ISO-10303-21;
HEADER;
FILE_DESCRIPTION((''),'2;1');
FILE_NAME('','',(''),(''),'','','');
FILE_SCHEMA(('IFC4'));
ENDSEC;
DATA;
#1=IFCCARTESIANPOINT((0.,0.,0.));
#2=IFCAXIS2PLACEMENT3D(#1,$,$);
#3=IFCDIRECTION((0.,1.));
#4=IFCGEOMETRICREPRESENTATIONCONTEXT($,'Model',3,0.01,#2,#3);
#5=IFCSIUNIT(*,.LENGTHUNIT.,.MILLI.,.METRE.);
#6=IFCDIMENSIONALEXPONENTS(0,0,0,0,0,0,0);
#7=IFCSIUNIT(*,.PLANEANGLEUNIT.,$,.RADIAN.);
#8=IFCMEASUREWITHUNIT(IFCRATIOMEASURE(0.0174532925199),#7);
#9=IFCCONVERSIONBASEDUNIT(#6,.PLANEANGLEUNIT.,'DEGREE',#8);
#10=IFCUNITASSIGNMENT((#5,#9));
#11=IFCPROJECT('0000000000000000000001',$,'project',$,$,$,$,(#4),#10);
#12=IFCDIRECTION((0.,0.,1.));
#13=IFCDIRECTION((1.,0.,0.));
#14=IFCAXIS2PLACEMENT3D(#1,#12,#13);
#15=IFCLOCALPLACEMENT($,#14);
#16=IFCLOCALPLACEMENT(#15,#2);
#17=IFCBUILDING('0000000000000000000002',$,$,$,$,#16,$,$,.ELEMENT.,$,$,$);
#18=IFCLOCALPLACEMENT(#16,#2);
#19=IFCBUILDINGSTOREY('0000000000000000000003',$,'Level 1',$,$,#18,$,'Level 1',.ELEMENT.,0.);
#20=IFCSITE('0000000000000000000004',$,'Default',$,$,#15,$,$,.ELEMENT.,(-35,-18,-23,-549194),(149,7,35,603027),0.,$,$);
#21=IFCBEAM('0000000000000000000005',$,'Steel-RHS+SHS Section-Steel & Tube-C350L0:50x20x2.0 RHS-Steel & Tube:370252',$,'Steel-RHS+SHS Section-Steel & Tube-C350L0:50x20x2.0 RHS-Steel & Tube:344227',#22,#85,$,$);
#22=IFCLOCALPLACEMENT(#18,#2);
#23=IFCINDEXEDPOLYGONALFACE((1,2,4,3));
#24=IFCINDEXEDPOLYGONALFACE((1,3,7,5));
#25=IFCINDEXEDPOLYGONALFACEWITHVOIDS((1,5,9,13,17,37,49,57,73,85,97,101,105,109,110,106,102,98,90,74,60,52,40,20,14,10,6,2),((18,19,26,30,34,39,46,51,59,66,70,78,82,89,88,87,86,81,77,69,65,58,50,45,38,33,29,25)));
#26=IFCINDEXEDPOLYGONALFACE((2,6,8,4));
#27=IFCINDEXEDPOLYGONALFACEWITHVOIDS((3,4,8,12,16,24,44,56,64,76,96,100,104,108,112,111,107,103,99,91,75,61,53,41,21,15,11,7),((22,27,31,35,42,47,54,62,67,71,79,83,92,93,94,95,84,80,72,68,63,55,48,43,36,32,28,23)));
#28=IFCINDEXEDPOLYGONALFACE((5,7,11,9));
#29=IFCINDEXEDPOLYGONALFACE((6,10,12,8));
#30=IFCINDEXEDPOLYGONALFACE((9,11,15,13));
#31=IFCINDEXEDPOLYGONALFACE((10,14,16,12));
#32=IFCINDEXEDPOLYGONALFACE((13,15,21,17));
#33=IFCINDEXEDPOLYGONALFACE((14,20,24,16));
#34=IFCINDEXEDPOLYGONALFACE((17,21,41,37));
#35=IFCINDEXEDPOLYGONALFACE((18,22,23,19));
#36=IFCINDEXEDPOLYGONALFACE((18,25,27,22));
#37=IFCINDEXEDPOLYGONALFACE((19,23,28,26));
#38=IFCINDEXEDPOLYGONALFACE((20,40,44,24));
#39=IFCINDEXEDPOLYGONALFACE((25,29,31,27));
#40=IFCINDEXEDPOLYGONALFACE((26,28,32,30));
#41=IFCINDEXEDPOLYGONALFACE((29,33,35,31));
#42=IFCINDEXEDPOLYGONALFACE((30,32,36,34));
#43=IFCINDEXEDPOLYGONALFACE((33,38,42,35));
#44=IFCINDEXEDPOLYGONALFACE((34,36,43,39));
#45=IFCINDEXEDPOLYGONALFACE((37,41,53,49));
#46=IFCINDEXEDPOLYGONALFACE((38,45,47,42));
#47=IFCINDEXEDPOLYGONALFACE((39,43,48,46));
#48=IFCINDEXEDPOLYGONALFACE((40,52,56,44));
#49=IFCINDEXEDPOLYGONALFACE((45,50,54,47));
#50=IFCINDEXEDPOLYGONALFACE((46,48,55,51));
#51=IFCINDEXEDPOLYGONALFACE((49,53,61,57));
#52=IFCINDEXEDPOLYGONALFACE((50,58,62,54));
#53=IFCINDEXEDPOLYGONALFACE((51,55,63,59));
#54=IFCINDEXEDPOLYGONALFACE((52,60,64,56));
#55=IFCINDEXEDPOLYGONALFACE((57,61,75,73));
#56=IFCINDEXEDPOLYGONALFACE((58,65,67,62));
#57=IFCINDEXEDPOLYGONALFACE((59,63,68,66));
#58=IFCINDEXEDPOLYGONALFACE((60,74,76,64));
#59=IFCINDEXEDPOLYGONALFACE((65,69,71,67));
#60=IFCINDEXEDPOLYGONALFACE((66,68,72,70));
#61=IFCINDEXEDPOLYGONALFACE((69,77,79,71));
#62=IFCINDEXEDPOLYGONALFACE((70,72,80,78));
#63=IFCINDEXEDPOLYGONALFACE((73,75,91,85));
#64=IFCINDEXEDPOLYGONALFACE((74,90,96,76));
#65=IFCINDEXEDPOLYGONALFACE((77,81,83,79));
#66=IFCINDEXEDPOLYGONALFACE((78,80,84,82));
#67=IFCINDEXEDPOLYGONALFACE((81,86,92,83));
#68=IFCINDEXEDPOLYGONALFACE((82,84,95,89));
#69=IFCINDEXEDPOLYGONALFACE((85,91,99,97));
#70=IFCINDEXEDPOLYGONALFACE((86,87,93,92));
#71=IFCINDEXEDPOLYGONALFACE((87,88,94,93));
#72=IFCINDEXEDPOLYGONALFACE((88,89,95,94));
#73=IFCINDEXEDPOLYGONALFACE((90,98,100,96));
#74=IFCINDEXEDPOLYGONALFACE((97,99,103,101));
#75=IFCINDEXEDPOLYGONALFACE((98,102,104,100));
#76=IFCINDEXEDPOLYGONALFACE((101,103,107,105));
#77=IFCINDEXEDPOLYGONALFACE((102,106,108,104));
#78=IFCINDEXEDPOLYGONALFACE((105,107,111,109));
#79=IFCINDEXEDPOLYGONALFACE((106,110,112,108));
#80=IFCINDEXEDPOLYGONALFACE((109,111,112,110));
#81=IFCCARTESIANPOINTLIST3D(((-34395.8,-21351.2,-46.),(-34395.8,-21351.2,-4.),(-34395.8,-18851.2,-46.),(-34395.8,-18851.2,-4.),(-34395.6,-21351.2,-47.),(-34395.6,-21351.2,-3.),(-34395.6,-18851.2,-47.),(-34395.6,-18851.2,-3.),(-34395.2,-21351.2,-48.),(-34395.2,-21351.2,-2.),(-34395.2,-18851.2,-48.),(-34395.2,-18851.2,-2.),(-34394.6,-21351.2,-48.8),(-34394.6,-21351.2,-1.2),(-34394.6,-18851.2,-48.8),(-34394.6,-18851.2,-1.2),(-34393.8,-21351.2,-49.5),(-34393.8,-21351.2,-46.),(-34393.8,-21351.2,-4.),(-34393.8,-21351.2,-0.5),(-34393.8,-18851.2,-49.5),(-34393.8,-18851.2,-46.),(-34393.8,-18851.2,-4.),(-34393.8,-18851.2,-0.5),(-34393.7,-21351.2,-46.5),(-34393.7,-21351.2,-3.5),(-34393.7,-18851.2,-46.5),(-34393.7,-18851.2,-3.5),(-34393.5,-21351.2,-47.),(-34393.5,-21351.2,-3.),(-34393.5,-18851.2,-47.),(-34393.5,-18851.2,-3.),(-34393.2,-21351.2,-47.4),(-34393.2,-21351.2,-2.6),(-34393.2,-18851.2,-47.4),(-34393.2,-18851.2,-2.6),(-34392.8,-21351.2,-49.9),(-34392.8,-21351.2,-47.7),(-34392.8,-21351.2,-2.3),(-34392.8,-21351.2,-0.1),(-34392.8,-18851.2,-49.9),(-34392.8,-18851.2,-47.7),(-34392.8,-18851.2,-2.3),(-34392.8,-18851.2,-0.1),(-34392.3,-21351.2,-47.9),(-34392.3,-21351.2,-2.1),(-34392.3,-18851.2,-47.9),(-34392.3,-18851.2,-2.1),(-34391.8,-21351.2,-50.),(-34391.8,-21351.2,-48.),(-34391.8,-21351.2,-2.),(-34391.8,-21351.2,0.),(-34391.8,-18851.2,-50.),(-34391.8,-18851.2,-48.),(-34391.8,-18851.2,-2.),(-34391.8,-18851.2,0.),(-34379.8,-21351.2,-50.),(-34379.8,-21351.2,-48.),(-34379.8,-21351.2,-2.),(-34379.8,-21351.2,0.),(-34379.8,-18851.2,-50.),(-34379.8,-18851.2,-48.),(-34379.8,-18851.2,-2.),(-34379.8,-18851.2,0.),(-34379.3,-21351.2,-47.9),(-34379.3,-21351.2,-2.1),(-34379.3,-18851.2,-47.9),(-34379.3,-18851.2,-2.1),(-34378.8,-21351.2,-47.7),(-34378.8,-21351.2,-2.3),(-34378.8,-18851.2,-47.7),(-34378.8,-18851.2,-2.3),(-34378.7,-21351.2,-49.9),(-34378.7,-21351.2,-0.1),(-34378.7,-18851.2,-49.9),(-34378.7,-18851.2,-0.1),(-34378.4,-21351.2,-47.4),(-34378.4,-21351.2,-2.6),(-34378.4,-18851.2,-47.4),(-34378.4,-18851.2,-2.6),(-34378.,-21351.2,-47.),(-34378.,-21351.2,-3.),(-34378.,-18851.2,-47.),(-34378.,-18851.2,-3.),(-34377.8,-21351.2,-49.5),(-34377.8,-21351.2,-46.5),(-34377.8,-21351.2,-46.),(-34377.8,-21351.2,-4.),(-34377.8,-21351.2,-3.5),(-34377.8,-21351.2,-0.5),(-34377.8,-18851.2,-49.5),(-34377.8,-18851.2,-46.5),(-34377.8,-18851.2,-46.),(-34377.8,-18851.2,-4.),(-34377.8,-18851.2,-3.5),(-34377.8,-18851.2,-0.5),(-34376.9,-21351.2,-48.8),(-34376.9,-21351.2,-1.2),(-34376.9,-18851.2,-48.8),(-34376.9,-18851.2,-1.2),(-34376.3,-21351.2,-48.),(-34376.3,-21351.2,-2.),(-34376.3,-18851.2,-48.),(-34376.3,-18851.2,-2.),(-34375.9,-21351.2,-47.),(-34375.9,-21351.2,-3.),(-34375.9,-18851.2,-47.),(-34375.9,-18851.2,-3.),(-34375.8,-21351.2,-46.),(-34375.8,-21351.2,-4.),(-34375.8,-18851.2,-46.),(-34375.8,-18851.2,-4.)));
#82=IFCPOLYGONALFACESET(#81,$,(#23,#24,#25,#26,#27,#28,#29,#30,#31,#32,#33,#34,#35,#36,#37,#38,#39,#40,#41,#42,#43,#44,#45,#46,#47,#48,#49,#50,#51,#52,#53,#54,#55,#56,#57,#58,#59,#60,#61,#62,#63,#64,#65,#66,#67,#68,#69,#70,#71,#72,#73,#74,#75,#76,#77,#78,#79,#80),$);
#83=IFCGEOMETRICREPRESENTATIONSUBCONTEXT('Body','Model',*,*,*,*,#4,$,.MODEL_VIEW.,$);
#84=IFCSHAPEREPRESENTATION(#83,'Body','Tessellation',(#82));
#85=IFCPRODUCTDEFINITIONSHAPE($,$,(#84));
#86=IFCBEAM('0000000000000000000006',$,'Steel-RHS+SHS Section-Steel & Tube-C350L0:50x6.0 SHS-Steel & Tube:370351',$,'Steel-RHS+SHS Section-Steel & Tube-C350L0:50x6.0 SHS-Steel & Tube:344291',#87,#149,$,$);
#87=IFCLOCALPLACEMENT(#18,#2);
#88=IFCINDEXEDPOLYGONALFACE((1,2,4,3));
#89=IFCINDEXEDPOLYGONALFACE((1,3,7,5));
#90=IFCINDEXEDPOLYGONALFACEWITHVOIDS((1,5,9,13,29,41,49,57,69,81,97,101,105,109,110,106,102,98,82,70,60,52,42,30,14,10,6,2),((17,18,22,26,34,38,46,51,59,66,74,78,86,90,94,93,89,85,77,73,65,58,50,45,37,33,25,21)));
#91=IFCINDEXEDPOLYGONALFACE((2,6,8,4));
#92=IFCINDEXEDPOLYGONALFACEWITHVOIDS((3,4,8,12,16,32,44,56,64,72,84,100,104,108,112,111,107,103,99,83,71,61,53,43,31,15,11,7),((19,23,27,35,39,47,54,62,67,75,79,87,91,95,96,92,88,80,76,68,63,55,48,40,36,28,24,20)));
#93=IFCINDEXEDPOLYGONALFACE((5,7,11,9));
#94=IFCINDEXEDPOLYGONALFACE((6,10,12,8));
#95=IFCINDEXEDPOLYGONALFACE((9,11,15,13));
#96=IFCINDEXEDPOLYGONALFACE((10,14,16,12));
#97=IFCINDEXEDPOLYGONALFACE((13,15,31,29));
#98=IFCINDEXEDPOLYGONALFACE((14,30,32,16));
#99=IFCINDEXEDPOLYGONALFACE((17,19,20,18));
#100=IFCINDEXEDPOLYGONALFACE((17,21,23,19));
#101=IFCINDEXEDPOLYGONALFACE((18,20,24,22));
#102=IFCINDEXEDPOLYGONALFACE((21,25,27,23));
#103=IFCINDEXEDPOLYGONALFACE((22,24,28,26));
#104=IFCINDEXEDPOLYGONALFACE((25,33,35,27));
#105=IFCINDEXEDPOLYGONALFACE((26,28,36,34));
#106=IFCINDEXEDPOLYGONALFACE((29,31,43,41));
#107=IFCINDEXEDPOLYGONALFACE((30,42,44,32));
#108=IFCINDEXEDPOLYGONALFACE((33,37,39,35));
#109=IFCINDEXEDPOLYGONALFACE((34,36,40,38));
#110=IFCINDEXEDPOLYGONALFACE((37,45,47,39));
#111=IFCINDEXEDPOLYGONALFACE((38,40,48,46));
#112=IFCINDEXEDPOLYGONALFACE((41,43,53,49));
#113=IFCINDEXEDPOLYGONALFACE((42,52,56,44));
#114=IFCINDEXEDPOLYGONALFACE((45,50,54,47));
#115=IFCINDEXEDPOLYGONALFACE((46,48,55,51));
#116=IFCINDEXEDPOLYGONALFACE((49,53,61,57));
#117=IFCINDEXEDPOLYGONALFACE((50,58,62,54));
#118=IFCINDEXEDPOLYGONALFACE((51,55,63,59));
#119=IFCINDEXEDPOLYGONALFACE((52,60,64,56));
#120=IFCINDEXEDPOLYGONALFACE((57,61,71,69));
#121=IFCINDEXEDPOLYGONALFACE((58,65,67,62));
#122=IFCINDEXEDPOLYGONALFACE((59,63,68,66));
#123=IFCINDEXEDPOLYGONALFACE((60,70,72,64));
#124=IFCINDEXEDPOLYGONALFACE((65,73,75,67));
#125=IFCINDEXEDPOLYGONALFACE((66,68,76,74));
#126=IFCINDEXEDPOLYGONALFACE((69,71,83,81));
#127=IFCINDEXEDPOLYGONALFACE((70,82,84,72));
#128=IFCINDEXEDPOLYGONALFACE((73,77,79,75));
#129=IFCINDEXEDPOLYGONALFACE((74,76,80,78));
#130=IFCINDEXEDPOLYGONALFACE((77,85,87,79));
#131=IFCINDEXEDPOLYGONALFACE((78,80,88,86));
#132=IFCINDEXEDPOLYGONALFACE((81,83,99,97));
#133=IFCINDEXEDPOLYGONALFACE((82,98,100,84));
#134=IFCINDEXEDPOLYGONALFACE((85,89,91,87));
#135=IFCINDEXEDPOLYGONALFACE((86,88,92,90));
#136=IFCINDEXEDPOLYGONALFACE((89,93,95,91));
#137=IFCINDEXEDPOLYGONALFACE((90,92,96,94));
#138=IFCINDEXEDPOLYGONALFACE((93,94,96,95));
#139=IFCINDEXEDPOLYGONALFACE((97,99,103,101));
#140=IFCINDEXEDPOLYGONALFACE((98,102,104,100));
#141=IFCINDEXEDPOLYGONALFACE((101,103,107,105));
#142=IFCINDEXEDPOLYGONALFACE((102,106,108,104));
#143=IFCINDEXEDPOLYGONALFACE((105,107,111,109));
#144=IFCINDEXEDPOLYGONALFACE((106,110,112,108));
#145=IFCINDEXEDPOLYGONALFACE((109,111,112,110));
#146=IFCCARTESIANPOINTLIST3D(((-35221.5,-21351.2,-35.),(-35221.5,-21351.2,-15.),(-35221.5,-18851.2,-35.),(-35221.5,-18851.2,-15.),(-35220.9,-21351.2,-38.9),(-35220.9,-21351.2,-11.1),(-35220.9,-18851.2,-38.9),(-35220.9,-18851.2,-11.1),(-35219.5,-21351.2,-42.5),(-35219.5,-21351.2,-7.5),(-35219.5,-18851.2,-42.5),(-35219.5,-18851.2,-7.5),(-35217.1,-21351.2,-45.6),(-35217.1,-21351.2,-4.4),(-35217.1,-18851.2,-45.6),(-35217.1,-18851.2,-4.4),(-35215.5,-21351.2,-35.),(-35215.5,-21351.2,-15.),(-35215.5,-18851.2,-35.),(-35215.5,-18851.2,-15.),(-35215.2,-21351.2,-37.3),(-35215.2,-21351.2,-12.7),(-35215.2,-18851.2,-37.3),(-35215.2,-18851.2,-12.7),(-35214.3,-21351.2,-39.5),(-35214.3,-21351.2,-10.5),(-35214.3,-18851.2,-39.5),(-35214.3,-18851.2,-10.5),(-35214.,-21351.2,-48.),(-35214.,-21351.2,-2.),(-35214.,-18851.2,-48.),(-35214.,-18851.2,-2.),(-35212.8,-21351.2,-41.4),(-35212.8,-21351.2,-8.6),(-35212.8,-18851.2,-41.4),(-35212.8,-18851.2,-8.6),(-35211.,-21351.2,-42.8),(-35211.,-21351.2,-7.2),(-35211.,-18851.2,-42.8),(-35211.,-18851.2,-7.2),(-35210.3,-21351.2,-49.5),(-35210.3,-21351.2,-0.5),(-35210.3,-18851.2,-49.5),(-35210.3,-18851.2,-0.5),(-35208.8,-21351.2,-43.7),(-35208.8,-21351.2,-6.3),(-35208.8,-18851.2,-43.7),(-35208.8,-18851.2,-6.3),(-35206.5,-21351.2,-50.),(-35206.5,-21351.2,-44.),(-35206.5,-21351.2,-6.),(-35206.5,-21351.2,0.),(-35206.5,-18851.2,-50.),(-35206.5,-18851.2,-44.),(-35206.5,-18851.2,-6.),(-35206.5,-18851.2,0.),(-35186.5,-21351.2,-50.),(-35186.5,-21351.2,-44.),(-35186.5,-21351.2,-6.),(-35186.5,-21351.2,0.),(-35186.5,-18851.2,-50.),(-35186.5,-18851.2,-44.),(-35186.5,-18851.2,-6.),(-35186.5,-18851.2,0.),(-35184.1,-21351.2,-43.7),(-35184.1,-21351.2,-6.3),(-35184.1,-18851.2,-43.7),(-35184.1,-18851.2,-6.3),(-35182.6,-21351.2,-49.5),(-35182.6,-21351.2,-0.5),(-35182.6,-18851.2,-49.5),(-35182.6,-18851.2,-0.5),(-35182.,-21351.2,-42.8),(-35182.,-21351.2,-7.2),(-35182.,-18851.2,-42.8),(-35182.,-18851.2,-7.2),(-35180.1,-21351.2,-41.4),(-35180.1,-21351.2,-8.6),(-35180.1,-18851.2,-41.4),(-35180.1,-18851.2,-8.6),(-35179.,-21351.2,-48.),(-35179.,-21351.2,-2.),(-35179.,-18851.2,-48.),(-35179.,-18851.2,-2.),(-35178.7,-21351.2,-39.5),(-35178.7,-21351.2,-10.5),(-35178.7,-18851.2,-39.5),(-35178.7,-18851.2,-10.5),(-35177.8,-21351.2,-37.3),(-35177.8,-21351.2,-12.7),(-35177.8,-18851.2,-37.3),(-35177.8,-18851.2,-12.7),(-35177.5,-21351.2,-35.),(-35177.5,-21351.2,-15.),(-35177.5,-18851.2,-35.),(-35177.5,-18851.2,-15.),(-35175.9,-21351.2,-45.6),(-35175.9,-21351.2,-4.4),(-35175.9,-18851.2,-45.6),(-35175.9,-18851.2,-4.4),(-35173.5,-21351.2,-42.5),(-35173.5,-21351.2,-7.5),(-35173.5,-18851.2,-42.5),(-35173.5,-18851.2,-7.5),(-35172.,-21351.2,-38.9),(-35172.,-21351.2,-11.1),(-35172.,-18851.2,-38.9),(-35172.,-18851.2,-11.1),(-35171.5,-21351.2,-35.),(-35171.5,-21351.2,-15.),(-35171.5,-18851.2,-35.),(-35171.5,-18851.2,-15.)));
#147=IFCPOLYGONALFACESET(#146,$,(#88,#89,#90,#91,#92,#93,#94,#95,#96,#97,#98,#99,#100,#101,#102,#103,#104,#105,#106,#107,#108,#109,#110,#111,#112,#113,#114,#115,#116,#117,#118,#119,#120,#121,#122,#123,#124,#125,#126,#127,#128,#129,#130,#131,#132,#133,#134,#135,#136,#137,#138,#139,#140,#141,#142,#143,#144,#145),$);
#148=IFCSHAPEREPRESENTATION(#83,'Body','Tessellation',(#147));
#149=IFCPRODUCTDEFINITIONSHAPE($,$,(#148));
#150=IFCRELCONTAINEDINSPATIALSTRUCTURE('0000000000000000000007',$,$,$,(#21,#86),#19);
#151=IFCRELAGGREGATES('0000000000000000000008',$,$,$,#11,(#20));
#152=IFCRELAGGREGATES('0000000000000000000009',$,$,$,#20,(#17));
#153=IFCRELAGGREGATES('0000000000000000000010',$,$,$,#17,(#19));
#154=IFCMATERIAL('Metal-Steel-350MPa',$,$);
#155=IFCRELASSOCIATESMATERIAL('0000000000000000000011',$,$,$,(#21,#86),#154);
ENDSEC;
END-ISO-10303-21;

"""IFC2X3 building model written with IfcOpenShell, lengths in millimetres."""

from ifc_helpers import new_model, entity, si_unit, converted_unit, direction, frame, frame_2d, origin, origin_with_axes, place, context, subcontext, project, spatial, polyline, circle_curve, parameter, trimmed, segment, composite_curve, outline, extrude, material, element, save


model = new_model("IFC2X3")

# Units and contexts
model_context = context("Model", 3, precision=0.01, world=origin(), true_north=direction((0.0, 1.0)))
body_context = subcontext(model_context, "Body", "Model", "MODEL_VIEW")
ifc_project = project(units=[si_unit("LENGTHUNIT", "METRE", prefix="MILLI"), converted_unit("PLANEANGLEUNIT", "DEGREE", entity("IfcRatioMeasure", 0.0174532925199), si_unit("PLANEANGLEUNIT", "RADIAN"), dimensions=[0, 0, 0, 0, 0, 0, 0])], contexts=[model_context])

# Site, building, storey
site_placement = place(None, origin_with_axes())
site = spatial("IfcSite", under=ifc_project, at=site_placement, Name="Default", CompositionType="ELEMENT", RefLatitude=(-35, -18, -23, -549194), RefLongitude=(149, 7, 35, 603027), RefElevation=0.0)
building_placement = place(site_placement, origin())
building = spatial("IfcBuilding", under=site, at=building_placement, CompositionType="ELEMENT")
storey_placement = place(building_placement, origin())
storey = spatial("IfcBuildingStorey", under=building, at=storey_placement, Name="Level 1", LongName="Level 1", CompositionType="ELEMENT", Elevation=0.0)

# Beams
ifc_material = material(Name="Metal-Steel-350MPa")
beam_1_placement = place(storey_placement, frame((-34385.8, -18851.2, 0.0), z_axis=(0.0, 0.0, 1.0), x_axis=(0.0, -1.0, 0.0)))
element("IfcBeam", 1, at=beam_1_placement, inside=storey, material=ifc_material, Name="Steel-RHS+SHS Section-Steel & Tube-C350L0:50x20x2.0 RHS-Steel & Tube:370252", ObjectType="Steel-RHS+SHS Section-Steel & Tube-C350L0:50x20x2.0 RHS-Steel & Tube:344227", context=body_context, shape_type="SweptSolid", body=[
    extrude(outline(composite_curve([segment(trimmed(circle_curve(frame_2d((-6.0, -21.0), x_axis=(1.0, 0.0)), 4.0), [parameter(180.0)], [parameter(270.0)], True, "PARAMETER"), True, "CONTINUOUS"), segment(polyline([(-6.0, -25.0), (6.0, -25.0)]), True, "CONTINUOUS"), segment(trimmed(circle_curve(frame_2d((6.0, -21.0), x_axis=(1.0, 0.0)), 4.0), [parameter(270.0)], [parameter(0.0)], True, "PARAMETER"), True, "CONTINUOUS"), segment(polyline([(10.0, -21.0), (10.0, 21.0)]), True, "CONTINUOUS"), segment(trimmed(circle_curve(frame_2d((6.0, 21.0), x_axis=(1.0, 0.0)), 4.0), [parameter(0.0)], [parameter(90.0)], True, "PARAMETER"), True, "CONTINUOUS"), segment(polyline([(6.0, 25.0), (-6.0, 25.0)]), True, "CONTINUOUS"), segment(trimmed(circle_curve(frame_2d((-6.0, 21.0), x_axis=(1.0, 0.0)), 4.0), [parameter(90.0)], [parameter(180.0)], True, "PARAMETER"), True, "CONTINUOUS"), segment(polyline([(-10.0, 21.0), (-10.0, -21.0)]), True, "CONTINUOUS")], self_intersect=False), holes=[composite_curve([segment(polyline([(6.0, -23.0), (-6.0, -23.0)]), True, "CONTINUOUS"), segment(trimmed(circle_curve(frame_2d((-6.0, -21.0), x_axis=(1.0, 0.0)), 2.0), [parameter(180.0)], [parameter(270.0)], True, "PARAMETER"), False, "CONTINUOUS"), segment(polyline([(-8.0, -21.0), (-8.0, 21.0)]), True, "CONTINUOUS"), segment(trimmed(circle_curve(frame_2d((-6.0, 21.0), x_axis=(1.0, 0.0)), 2.0), [parameter(90.0)], [parameter(180.0)], True, "PARAMETER"), False, "CONTINUOUS"), segment(polyline([(-6.0, 23.0), (6.0, 23.0)]), True, "CONTINUOUS"), segment(trimmed(circle_curve(frame_2d((6.0, 21.0), x_axis=(1.0, 0.0)), 2.0), [parameter(360.0)], [parameter(90.0)], True, "PARAMETER"), False, "CONTINUOUS"), segment(polyline([(8.0, 21.0), (8.0, -21.0)]), True, "CONTINUOUS"), segment(trimmed(circle_curve(frame_2d((6.0, -21.0), x_axis=(1.0, 0.0)), 2.0), [parameter(270.0)], [parameter(360.0)], True, "PARAMETER"), False, "CONTINUOUS")], self_intersect=False)]), frame((0.0, 0.0, -25.0), z_axis=(1.0, 0.0, 0.0), x_axis=(0.0, -1.0, 0.0)), (0.0, 0.0, 1.0), 2500.0),
])
beam_2_placement = place(storey_placement, frame((-35196.5, -18851.2, 0.0), z_axis=(0.0, 0.0, 1.0), x_axis=(0.0, -1.0, 0.0)))
element("IfcBeam", 2, at=beam_2_placement, inside=storey, material=ifc_material, Name="Steel-RHS+SHS Section-Steel & Tube-C350L0:50x6.0 SHS-Steel & Tube:370351", ObjectType="Steel-RHS+SHS Section-Steel & Tube-C350L0:50x6.0 SHS-Steel & Tube:344291", context=body_context, shape_type="SweptSolid", body=[
    extrude(outline(composite_curve([segment(trimmed(circle_curve(frame_2d((-10.0, -10.0), x_axis=(1.0, 0.0)), 15.0), [parameter(180.0)], [parameter(270.0)], True, "PARAMETER"), True, "CONTINUOUS"), segment(polyline([(-10.0, -25.0), (10.0, -25.0)]), True, "CONTINUOUS"), segment(trimmed(circle_curve(frame_2d((10.0, -10.0), x_axis=(1.0, 0.0)), 15.0), [parameter(270.0)], [parameter(0.0)], True, "PARAMETER"), True, "CONTINUOUS"), segment(polyline([(25.0, -10.0), (25.0, 10.0)]), True, "CONTINUOUS"), segment(trimmed(circle_curve(frame_2d((10.0, 10.0), x_axis=(1.0, 0.0)), 15.0), [parameter(0.0)], [parameter(90.0)], True, "PARAMETER"), True, "CONTINUOUS"), segment(polyline([(10.0, 25.0), (-10.0, 25.0)]), True, "CONTINUOUS"), segment(trimmed(circle_curve(frame_2d((-10.0, 10.0), x_axis=(1.0, 0.0)), 15.0), [parameter(90.0)], [parameter(180.0)], True, "PARAMETER"), True, "CONTINUOUS"), segment(polyline([(-25.0, 10.0), (-25.0, -10.0)]), True, "CONTINUOUS")], self_intersect=False), holes=[composite_curve([segment(polyline([(10.0, -19.0), (-10.0, -19.0)]), True, "CONTINUOUS"), segment(trimmed(circle_curve(frame_2d((-10.0, -10.0), x_axis=(1.0, 0.0)), 9.0), [parameter(180.0)], [parameter(270.0)], True, "PARAMETER"), False, "CONTINUOUS"), segment(polyline([(-19.0, -10.0), (-19.0, 10.0)]), True, "CONTINUOUS"), segment(trimmed(circle_curve(frame_2d((-10.0, 10.0), x_axis=(1.0, 0.0)), 9.0), [parameter(90.0)], [parameter(180.0)], True, "PARAMETER"), False, "CONTINUOUS"), segment(polyline([(-10.0, 19.0), (10.0, 19.0)]), True, "CONTINUOUS"), segment(trimmed(circle_curve(frame_2d((10.0, 10.0), x_axis=(1.0, 0.0)), 9.0), [parameter(360.0)], [parameter(90.0)], True, "PARAMETER"), False, "CONTINUOUS"), segment(polyline([(19.0, 10.0), (19.0, -10.0)]), True, "CONTINUOUS"), segment(trimmed(circle_curve(frame_2d((10.0, -10.0), x_axis=(1.0, 0.0)), 9.0), [parameter(270.0)], [parameter(360.0)], True, "PARAMETER"), False, "CONTINUOUS")], self_intersect=False)]), frame((0.0, 0.0, -25.0), z_axis=(1.0, 0.0, 0.0), x_axis=(0.0, -1.0, 0.0)), (0.0, 0.0, 1.0), 2500.0),
])

save(model, "model.ifc")
